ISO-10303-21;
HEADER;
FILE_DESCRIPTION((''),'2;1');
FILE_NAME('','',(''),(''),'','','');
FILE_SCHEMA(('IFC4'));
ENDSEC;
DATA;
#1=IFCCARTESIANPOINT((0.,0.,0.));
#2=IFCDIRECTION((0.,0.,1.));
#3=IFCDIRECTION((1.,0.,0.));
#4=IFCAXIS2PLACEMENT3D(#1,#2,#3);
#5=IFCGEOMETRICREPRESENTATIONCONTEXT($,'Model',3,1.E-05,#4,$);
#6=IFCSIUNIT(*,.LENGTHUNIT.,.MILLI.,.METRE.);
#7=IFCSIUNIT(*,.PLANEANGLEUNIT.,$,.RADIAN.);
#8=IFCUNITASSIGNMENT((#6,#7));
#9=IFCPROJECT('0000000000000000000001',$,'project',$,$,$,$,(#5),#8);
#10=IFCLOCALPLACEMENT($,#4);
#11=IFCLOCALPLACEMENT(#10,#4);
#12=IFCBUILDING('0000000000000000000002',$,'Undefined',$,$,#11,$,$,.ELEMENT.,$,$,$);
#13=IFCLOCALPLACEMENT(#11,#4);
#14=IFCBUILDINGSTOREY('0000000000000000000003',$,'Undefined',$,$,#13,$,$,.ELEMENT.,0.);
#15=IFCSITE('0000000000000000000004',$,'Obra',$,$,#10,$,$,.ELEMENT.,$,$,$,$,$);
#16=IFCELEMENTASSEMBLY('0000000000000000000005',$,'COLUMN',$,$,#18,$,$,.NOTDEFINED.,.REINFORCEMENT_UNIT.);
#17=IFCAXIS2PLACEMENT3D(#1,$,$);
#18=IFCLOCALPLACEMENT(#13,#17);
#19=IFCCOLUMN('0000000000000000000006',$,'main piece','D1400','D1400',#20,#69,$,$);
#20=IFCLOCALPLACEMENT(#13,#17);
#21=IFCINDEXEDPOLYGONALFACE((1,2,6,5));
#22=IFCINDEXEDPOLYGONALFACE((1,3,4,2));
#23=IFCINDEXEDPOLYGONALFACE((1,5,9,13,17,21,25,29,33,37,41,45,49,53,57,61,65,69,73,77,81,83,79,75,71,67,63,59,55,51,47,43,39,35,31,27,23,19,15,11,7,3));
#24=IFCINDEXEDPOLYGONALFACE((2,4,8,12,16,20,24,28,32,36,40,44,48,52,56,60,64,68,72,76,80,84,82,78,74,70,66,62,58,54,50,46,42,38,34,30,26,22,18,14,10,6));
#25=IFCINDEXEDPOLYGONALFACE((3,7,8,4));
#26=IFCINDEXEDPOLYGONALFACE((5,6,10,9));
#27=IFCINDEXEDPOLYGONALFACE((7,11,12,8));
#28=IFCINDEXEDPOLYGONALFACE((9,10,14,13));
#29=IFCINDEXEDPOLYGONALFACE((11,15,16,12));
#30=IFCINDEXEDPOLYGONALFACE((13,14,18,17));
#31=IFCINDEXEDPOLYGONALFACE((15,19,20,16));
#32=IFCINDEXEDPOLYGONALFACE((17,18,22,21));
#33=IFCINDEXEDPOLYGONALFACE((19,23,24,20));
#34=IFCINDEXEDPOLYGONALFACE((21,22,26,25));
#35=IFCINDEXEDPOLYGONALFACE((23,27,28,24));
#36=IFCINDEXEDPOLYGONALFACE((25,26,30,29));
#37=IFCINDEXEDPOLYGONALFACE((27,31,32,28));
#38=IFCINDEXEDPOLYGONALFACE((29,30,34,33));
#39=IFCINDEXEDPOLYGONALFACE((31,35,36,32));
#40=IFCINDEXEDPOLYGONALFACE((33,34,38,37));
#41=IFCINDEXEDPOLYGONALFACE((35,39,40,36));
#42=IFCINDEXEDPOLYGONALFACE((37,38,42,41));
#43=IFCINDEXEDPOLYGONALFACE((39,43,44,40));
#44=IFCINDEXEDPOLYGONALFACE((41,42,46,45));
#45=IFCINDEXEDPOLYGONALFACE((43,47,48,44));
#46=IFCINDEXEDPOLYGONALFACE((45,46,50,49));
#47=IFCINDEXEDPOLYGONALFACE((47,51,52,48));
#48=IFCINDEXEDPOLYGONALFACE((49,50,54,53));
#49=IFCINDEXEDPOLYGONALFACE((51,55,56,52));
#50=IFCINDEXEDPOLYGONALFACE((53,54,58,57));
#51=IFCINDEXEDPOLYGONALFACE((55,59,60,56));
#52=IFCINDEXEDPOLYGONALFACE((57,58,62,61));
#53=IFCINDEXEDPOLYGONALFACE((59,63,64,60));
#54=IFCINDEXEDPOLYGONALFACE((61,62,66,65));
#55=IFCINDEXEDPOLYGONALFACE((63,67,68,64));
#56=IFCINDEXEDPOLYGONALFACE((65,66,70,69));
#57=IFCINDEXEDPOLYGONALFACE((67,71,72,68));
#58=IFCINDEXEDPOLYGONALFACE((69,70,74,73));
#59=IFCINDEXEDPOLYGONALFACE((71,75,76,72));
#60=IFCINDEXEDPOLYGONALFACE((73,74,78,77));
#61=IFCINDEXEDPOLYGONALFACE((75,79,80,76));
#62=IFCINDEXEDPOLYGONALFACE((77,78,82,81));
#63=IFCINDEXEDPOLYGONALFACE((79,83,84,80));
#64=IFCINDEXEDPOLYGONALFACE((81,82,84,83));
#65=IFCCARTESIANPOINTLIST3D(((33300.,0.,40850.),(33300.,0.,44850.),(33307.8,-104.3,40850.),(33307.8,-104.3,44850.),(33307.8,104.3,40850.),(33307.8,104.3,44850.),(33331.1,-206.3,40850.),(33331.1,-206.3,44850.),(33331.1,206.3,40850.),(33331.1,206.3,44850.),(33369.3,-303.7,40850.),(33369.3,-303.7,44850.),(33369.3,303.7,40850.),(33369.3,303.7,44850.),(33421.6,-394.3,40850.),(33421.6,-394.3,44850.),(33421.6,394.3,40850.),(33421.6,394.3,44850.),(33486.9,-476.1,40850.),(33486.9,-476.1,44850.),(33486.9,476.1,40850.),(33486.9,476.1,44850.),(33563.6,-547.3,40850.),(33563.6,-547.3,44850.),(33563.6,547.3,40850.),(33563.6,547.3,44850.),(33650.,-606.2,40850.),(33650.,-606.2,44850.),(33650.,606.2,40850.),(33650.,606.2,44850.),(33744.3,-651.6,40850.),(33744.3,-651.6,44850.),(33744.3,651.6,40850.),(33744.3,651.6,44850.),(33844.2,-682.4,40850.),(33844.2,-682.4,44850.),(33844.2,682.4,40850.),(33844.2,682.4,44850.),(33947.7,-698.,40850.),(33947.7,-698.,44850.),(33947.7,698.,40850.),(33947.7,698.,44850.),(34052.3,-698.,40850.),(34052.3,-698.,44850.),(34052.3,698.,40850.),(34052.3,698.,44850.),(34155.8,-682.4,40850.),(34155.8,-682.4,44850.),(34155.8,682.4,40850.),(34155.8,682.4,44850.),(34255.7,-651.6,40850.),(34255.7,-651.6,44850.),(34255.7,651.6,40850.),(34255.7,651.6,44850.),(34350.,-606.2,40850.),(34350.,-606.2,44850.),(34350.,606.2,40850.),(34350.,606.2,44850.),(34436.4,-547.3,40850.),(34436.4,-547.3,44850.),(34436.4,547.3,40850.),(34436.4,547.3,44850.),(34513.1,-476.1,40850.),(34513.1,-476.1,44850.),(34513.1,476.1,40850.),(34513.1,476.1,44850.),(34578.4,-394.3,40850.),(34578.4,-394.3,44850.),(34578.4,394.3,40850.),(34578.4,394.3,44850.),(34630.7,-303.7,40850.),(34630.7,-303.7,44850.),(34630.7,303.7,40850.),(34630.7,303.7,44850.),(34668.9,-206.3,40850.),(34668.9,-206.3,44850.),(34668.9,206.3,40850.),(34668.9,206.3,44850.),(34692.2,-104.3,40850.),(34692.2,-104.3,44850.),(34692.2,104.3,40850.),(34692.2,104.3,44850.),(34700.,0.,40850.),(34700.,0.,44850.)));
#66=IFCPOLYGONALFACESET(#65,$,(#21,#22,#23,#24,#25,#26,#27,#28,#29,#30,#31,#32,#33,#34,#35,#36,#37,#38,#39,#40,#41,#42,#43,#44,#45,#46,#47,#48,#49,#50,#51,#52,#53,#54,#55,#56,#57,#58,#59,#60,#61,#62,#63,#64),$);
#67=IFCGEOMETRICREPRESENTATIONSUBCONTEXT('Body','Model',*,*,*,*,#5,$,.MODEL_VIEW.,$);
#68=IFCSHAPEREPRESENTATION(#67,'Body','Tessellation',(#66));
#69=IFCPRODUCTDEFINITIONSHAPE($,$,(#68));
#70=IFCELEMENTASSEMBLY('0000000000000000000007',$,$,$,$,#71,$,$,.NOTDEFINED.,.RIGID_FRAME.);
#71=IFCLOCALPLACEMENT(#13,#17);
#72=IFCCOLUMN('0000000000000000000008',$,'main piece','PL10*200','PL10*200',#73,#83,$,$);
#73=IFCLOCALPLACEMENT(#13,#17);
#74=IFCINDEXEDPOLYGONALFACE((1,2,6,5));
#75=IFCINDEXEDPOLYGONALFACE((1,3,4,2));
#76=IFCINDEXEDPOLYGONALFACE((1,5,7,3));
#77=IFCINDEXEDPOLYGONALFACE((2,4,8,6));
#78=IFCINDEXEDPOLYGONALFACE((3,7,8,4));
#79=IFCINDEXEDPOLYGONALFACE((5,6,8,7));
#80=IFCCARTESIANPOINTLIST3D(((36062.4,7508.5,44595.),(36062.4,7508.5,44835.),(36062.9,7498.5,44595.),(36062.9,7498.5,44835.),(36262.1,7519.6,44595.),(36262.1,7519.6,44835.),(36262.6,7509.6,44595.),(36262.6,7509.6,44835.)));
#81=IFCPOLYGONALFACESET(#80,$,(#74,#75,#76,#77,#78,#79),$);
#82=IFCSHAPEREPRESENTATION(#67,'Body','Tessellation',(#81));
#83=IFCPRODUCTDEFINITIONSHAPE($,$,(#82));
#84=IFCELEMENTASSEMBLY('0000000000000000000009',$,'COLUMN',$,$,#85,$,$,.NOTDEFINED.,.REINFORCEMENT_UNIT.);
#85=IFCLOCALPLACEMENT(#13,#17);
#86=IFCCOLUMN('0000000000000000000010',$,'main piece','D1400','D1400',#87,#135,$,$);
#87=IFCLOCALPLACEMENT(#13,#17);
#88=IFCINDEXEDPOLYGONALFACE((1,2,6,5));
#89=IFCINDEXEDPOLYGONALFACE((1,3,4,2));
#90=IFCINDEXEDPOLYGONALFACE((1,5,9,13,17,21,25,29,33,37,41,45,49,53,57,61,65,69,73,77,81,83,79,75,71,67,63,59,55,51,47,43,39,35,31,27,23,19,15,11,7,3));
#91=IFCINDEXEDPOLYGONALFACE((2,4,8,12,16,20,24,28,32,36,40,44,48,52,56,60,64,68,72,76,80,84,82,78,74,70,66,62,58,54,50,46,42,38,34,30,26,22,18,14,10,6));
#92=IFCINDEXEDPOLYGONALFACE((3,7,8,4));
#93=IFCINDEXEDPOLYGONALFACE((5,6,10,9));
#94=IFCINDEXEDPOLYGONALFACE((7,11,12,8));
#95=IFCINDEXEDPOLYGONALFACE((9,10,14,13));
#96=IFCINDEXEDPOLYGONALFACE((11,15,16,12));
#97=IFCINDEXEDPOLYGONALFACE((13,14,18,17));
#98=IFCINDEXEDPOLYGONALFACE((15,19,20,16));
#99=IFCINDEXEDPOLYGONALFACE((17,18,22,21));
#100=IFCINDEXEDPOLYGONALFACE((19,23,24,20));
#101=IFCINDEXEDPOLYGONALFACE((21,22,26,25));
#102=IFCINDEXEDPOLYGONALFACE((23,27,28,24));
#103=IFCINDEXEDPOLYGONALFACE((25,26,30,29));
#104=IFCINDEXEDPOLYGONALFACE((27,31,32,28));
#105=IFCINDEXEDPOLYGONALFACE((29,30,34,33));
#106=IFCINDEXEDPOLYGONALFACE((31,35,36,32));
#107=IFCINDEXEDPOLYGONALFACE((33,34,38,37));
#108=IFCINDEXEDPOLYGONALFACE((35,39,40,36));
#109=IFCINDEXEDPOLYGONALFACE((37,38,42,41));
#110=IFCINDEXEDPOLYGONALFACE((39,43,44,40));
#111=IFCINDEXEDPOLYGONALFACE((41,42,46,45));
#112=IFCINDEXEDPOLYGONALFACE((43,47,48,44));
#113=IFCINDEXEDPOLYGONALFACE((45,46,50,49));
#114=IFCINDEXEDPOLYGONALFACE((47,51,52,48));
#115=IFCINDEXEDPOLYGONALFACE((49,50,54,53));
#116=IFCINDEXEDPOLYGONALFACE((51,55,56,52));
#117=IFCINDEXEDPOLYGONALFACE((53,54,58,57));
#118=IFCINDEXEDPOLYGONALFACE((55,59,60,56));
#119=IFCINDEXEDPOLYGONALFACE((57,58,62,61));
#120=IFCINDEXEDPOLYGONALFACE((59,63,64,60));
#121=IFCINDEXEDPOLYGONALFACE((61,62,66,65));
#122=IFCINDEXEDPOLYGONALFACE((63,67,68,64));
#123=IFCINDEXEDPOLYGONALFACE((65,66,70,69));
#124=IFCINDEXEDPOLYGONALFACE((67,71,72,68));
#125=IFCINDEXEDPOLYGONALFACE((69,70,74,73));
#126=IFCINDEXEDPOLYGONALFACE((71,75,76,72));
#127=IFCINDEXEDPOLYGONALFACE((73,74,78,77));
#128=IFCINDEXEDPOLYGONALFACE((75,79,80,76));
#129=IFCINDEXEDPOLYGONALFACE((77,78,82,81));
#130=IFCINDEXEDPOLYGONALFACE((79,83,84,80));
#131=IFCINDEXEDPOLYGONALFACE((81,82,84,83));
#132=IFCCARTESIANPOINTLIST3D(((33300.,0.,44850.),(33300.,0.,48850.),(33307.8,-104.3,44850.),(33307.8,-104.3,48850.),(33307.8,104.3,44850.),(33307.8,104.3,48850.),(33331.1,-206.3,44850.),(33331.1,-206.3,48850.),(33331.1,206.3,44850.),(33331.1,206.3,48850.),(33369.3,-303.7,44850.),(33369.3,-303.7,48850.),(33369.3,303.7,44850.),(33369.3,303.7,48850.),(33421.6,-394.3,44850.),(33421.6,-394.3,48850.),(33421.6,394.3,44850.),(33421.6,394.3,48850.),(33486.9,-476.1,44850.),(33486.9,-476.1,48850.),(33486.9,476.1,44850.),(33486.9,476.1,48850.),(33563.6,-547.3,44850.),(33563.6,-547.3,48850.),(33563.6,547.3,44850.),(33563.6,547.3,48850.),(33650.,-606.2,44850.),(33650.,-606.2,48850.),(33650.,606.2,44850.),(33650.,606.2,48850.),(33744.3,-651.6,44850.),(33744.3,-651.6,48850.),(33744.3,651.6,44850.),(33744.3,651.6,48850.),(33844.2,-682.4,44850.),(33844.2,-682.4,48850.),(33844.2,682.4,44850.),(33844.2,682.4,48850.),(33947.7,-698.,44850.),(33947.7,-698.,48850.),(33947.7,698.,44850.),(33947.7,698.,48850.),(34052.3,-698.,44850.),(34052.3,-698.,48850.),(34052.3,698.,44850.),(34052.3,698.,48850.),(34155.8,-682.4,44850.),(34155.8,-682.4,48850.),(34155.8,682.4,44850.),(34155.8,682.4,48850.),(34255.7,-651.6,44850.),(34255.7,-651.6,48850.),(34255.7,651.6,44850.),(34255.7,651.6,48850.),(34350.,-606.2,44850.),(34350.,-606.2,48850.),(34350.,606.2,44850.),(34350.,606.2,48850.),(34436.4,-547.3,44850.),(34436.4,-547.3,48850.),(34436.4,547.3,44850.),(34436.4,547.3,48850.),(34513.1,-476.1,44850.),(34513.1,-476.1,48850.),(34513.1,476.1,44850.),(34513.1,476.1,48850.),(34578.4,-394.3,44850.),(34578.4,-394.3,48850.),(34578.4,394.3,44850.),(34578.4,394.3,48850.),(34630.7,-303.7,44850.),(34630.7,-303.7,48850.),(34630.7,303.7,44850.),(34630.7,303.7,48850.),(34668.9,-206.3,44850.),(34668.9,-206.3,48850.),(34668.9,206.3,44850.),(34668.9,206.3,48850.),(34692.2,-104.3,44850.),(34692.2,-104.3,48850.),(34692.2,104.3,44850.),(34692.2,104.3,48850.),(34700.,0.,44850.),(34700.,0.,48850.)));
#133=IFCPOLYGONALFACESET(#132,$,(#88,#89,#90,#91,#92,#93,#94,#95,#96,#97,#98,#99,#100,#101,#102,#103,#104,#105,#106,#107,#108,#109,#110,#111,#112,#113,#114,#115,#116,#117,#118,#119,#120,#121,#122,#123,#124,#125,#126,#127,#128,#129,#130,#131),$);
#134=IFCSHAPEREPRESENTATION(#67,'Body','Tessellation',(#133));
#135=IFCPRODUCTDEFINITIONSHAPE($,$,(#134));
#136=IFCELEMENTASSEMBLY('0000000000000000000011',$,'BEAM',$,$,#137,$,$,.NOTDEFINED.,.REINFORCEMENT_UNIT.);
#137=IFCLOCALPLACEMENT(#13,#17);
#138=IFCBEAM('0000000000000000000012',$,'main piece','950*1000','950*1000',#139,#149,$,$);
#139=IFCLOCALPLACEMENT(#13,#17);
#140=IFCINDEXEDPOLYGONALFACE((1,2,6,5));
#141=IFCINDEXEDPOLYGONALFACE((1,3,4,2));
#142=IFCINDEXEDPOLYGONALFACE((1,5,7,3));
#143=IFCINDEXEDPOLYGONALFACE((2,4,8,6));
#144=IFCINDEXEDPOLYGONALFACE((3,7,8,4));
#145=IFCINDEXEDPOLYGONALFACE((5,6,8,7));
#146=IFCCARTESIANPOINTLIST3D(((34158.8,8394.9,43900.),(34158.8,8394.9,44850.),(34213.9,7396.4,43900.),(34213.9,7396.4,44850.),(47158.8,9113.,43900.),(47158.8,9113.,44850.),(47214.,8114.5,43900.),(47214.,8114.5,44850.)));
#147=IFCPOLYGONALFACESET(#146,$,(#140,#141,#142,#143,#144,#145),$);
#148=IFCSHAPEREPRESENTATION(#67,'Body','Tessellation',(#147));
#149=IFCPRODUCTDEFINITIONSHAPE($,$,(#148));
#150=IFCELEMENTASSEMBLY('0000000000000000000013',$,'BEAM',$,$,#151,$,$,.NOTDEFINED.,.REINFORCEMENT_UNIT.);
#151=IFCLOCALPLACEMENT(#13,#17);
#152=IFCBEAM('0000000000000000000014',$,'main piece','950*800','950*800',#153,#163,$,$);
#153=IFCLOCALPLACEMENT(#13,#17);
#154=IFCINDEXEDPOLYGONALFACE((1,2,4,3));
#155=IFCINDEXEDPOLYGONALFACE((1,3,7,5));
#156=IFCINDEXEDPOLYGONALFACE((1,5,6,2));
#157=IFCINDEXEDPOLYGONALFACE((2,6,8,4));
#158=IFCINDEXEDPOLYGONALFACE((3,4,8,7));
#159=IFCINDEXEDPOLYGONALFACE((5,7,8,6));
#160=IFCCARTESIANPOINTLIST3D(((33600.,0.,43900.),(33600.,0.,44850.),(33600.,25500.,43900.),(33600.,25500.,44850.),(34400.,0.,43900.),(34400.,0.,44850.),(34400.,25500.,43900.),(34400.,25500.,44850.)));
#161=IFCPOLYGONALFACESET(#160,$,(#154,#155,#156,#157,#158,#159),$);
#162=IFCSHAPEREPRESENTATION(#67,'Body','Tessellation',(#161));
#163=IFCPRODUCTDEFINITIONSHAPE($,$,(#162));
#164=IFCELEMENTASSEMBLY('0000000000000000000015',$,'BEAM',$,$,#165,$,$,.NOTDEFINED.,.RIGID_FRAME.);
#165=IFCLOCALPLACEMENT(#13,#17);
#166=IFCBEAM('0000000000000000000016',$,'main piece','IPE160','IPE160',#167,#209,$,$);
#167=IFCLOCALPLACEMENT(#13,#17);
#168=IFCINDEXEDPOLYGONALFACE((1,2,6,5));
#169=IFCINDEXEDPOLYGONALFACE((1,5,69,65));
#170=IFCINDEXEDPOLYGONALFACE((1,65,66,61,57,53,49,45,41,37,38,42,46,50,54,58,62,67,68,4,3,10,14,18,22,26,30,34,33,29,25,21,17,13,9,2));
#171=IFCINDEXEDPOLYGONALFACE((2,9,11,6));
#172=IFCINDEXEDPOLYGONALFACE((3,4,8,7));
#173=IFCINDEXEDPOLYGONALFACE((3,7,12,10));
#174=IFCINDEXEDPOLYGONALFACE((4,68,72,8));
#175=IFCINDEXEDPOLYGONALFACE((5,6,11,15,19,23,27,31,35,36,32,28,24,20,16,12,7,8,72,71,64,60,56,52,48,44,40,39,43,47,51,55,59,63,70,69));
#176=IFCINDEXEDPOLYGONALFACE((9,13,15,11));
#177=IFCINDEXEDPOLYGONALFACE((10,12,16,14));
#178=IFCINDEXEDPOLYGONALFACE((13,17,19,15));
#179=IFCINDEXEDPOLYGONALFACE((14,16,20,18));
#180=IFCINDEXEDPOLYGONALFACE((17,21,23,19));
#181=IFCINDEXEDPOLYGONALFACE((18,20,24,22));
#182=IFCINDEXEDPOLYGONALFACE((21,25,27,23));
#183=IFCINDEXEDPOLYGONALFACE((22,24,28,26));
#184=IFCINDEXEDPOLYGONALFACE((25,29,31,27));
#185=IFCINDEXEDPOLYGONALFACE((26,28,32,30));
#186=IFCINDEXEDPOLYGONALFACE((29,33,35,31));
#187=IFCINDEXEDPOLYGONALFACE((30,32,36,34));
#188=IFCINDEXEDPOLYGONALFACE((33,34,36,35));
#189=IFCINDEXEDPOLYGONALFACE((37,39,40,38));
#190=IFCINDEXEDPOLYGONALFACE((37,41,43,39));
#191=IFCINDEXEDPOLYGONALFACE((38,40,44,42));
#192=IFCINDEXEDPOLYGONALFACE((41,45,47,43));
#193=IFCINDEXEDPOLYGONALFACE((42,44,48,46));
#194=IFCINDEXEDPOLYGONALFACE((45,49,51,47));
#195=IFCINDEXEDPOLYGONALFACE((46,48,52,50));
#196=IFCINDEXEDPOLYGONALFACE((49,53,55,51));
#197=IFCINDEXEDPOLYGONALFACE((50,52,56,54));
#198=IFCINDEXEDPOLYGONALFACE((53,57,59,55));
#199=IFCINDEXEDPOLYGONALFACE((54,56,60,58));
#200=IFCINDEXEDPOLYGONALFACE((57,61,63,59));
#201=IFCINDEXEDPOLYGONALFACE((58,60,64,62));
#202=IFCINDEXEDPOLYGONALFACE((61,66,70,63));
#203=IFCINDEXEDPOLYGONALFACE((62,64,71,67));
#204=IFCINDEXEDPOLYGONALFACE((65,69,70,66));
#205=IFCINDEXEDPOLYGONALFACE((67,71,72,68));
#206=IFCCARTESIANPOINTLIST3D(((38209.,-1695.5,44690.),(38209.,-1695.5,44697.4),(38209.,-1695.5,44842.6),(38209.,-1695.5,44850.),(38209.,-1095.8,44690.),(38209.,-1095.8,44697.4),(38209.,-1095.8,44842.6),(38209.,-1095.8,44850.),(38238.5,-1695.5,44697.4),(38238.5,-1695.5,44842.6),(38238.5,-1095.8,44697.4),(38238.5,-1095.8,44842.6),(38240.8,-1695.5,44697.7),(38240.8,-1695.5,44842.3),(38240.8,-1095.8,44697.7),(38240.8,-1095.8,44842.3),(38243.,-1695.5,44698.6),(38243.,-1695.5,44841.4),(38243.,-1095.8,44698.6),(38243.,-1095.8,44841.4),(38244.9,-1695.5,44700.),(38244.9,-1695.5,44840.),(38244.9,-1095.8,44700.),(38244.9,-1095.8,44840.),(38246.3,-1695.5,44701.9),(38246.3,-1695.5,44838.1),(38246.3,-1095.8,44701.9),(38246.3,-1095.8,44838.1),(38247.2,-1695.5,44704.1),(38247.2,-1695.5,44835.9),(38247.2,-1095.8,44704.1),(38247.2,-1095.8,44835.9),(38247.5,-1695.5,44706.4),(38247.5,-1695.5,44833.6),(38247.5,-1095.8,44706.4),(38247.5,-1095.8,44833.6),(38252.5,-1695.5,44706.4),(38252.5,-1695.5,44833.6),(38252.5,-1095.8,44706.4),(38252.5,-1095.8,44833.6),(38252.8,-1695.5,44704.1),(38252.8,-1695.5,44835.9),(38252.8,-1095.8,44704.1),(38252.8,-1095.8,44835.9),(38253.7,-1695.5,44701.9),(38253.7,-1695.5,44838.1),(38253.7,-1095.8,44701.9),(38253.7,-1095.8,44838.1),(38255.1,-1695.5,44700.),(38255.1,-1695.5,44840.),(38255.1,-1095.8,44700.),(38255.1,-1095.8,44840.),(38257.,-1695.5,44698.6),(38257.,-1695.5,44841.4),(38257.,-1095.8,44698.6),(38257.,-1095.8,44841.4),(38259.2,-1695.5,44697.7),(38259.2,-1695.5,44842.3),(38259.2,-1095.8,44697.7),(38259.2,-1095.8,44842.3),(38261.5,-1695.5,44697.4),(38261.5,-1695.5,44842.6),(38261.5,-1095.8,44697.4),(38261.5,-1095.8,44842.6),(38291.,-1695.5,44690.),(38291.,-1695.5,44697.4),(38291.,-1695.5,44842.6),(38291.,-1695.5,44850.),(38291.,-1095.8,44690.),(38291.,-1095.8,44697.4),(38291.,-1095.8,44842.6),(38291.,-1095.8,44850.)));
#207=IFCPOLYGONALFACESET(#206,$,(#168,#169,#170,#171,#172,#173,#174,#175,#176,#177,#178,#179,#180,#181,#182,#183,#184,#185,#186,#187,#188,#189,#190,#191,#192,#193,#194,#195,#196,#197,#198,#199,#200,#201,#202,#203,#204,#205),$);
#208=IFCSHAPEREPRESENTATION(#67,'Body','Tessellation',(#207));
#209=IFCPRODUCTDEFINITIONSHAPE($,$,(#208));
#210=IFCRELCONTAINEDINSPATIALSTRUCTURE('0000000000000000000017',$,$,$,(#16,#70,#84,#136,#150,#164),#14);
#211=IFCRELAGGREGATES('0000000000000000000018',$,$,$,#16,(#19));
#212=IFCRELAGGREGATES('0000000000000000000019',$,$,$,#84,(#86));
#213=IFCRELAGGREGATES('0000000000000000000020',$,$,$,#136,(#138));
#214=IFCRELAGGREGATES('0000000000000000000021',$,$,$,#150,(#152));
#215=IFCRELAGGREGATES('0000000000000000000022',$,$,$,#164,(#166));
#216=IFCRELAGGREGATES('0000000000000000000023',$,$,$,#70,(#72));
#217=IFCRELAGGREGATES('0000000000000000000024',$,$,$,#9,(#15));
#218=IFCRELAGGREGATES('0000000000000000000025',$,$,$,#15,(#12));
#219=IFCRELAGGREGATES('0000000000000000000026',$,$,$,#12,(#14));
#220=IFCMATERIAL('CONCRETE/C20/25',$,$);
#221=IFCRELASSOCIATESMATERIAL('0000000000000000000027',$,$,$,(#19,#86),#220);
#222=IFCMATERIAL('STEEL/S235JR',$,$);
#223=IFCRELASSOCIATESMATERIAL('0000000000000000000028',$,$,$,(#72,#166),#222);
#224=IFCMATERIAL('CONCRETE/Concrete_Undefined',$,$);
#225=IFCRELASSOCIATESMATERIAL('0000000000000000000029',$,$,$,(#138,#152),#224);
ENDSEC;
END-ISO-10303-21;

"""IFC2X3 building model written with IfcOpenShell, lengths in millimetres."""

from ifc_helpers import new_model, si_unit, frame, origin_with_axes, origin_2d_with_axis, place, context, subcontext, project, spatial, rectangle, circle, i_section, extrude, material, element, aggregate, save


model = new_model("IFC2X3")

# Units and contexts
model_context = context("Model", 3, precision=1e-05, world=origin_with_axes())
body_context = subcontext(model_context, "Body", "Model", "MODEL_VIEW")
ifc_project = project(units=[si_unit("LENGTHUNIT", "METRE", prefix="MILLI"), si_unit("PLANEANGLEUNIT", "RADIAN")], contexts=[model_context])

# Site, building, storey
site_placement = place(None, origin_with_axes())
site = spatial("IfcSite", under=ifc_project, at=site_placement, Name="Obra", CompositionType="ELEMENT")
building_placement = place(site_placement, origin_with_axes())
building = spatial("IfcBuilding", under=site, at=building_placement, Name="Undefined", CompositionType="ELEMENT")
storey_placement = place(building_placement, origin_with_axes())
storey = spatial("IfcBuildingStorey", under=building, at=storey_placement, Name="Undefined", CompositionType="ELEMENT", Elevation=0.0)

# Element assemblies, columns
assembly_1_placement = place(storey_placement, origin_with_axes())
assembly_1 = element("IfcElementAssembly", 1, at=assembly_1_placement, inside=storey, Name="COLUMN", AssemblyPlace="NOTDEFINED", PredefinedType="REINFORCEMENT_UNIT")
ifc_material_1 = material(Name="CONCRETE/C20/25")
column_1_placement = place(assembly_1_placement, frame((34000.0, 0.0, 40850.0), z_axis=(0.0, 0.0, 1.0), x_axis=(0.0, 1.0, 0.0)))
column_1 = element("IfcColumn", 2, at=column_1_placement, material=ifc_material_1, Name="main piece", Description="D1400", ObjectType="D1400", context=body_context, shape_type="SweptSolid", body=[
    extrude(circle(Radius=700.0, at=origin_2d_with_axis()), frame((0.0, 0.0, 4000.0), z_axis=(0.0, 0.0, -1.0), x_axis=(0.0, 1.0, 0.0)), (0.0, 0.0, 1.0), 4000.0),
])
aggregate(assembly_1, [column_1])
assembly_2_placement = place(storey_placement, origin_with_axes())
assembly_2 = element("IfcElementAssembly", 3, at=assembly_2_placement, inside=storey, AssemblyPlace="NOTDEFINED", PredefinedType="RIGID_FRAME")
ifc_material_2 = material(Name="STEEL/S235JR")
column_2_placement = place(assembly_2_placement, frame((36162.5, 7509.1, 44595.0), z_axis=(0.0, 0.0, 1.0), x_axis=(-0.998478, -0.055152, 0.0)))
column_2 = element("IfcColumn", 4, at=column_2_placement, material=ifc_material_2, Name="main piece", Description="PL10*200", ObjectType="PL10*200", context=body_context, shape_type="SweptSolid", body=[
    extrude(rectangle(XDim=10.0, YDim=200.0, at=origin_2d_with_axis()), frame((0.0, 0.0, 240.0), z_axis=(0.0, 0.0, -1.0), x_axis=(0.0, 1.0, 0.0)), (0.0, 0.0, 1.0), 240.0),
])
assembly_3_placement = place(storey_placement, origin_with_axes())
assembly_3 = element("IfcElementAssembly", 5, at=assembly_3_placement, inside=storey, Name="COLUMN", AssemblyPlace="NOTDEFINED", PredefinedType="REINFORCEMENT_UNIT")
column_3_placement = place(assembly_3_placement, frame((34000.0, 0.0, 44850.0), z_axis=(0.0, 0.0, 1.0), x_axis=(0.0, 1.0, 0.0)))
column_3 = element("IfcColumn", 6, at=column_3_placement, material=ifc_material_1, Name="main piece", Description="D1400", ObjectType="D1400", context=body_context, shape_type="SweptSolid", body=[
    extrude(circle(Radius=700.0, at=origin_2d_with_axis()), frame((0.0, 0.0, 4000.0), z_axis=(0.0, 0.0, -1.0), x_axis=(0.0, 1.0, 0.0)), (0.0, 0.0, 1.0), 4000.0),
])
aggregate(assembly_3, [column_3])

# Element assemblies, beams
assembly_4_placement = place(storey_placement, origin_with_axes())
assembly_4 = element("IfcElementAssembly", 7, at=assembly_4_placement, inside=storey, Name="BEAM", AssemblyPlace="NOTDEFINED", PredefinedType="REINFORCEMENT_UNIT")
ifc_material_3 = material(Name="CONCRETE/Concrete_Undefined")
beam_1_placement = place(assembly_4_placement, frame((34186.4, 7895.7, 44375.0), z_axis=(0.0, 0.0, 1.0), x_axis=(0.998478, 0.055152, 0.0)))
beam_1 = element("IfcBeam", 8, at=beam_1_placement, material=ifc_material_3, Name="main piece", Description="950*1000", ObjectType="950*1000", context=body_context, shape_type="SweptSolid", body=[
    extrude(rectangle(XDim=1000.0, YDim=950.0, at=origin_2d_with_axis()), frame((13019.8, 0.0, 0.0), z_axis=(-1.0, 0.0, 0.0), x_axis=(0.0, -1.0, 0.0)), (0.0, 0.0, 1.0), 13019.8),
])
aggregate(assembly_4, [beam_1])
assembly_5_placement = place(storey_placement, origin_with_axes())
assembly_5 = element("IfcElementAssembly", 9, at=assembly_5_placement, inside=storey, Name="BEAM", AssemblyPlace="NOTDEFINED", PredefinedType="REINFORCEMENT_UNIT")
beam_2_placement = place(assembly_5_placement, frame((34000.0, 0.0, 44375.0), z_axis=(0.0, 0.0, 1.0), x_axis=(0.0, 1.0, 0.0)))
beam_2 = element("IfcBeam", 10, at=beam_2_placement, material=ifc_material_3, Name="main piece", Description="950*800", ObjectType="950*800", context=body_context, shape_type="SweptSolid", body=[
    extrude(rectangle(XDim=800.0, YDim=950.0, at=origin_2d_with_axis()), frame((25500.0, 0.0, 0.0), z_axis=(-1.0, 0.0, 0.0), x_axis=(0.0, -1.0, 0.0)), (0.0, 0.0, 1.0), 25500.0),
])
aggregate(assembly_5, [beam_2])
assembly_6_placement = place(storey_placement, origin_with_axes())
assembly_6 = element("IfcElementAssembly", 11, at=assembly_6_placement, inside=storey, Name="BEAM", AssemblyPlace="NOTDEFINED", PredefinedType="RIGID_FRAME")
beam_3_placement = place(assembly_6_placement, frame((38250.0, -1095.8, 44770.0), z_axis=(0.0, 0.0, 1.0), x_axis=(0.0, -1.0, 0.0)))
beam_3 = element("IfcBeam", 12, at=beam_3_placement, material=ifc_material_2, Name="main piece", Description="IPE160", ObjectType="IPE160", context=body_context, shape_type="SweptSolid", body=[
    extrude(i_section(OverallWidth=82.0, OverallDepth=160.0, WebThickness=5.0, FlangeThickness=7.4, FilletRadius=9.0, at=origin_2d_with_axis()), frame((599.7, 0.0, 0.0), z_axis=(-1.0, 0.0, 0.0), x_axis=(0.0, -1.0, 0.0)), (0.0, 0.0, 1.0), 599.7),
])
aggregate(assembly_6, [beam_3])

aggregate(assembly_2, [column_2])

save(model, "model.ifc")
